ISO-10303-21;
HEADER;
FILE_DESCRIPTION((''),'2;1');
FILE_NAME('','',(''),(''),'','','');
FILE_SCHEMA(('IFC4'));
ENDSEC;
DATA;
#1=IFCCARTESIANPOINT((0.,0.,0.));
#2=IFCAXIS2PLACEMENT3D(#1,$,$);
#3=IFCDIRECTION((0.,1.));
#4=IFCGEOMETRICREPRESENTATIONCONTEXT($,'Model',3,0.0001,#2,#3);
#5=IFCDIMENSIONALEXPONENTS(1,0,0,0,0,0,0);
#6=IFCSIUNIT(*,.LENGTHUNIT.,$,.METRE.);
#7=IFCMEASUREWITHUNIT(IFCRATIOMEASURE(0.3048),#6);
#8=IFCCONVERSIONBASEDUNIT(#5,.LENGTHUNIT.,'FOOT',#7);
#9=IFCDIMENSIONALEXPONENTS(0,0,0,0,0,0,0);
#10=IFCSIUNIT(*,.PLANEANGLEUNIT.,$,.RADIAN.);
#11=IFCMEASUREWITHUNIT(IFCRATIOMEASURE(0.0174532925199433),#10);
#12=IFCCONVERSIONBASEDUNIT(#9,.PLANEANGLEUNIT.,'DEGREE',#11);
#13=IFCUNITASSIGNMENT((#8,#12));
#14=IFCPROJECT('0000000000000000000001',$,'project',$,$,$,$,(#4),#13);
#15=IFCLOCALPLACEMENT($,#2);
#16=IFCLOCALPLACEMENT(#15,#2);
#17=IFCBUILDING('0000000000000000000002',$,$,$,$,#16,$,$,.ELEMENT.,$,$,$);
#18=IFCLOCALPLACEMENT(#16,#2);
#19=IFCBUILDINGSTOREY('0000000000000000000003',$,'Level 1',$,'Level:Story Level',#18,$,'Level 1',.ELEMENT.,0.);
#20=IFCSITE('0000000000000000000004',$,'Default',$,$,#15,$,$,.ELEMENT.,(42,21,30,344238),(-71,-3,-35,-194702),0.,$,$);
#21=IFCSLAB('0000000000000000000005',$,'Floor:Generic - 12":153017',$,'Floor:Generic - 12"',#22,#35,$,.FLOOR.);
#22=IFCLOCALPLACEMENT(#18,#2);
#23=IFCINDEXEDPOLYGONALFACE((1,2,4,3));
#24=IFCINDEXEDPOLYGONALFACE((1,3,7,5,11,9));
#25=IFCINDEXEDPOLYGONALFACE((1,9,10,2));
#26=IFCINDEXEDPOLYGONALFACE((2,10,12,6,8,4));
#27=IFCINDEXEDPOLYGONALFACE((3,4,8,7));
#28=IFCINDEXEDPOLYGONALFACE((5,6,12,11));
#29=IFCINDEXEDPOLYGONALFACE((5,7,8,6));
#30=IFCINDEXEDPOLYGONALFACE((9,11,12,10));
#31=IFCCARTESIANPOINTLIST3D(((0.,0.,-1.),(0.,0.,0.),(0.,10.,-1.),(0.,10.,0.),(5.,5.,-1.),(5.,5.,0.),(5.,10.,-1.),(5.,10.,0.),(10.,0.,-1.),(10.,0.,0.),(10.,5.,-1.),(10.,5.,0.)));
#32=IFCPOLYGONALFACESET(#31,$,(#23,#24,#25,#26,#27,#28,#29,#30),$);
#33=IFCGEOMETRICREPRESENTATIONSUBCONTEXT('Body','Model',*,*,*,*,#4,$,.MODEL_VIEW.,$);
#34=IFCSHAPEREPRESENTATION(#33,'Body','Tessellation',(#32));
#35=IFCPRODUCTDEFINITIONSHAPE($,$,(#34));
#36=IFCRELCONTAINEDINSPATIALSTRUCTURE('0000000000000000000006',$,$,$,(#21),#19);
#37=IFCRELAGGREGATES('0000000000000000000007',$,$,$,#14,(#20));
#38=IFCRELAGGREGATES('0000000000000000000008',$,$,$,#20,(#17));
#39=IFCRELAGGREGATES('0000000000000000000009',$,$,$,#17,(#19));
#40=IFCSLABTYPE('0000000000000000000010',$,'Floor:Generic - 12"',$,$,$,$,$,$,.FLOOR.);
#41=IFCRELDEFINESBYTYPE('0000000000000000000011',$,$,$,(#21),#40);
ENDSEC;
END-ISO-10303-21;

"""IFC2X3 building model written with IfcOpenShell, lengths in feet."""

from ifc_helpers import new_model, entity, si_unit, converted_unit, direction, frame, origin, place, context, subcontext, project, spatial, polyline, outline, extrude, type_object, element, save


model = new_model("IFC2X3")

# Units and contexts
model_context = context("Model", 3, precision=0.0001, world=origin(), true_north=direction((0.0, 1.0)))
body_context = subcontext(model_context, "Body", "Model", "MODEL_VIEW")
ifc_project = project(units=[converted_unit("LENGTHUNIT", "FOOT", entity("IfcRatioMeasure", 0.3048), si_unit("LENGTHUNIT", "METRE"), dimensions=[1, 0, 0, 0, 0, 0, 0]), converted_unit("PLANEANGLEUNIT", "DEGREE", entity("IfcRatioMeasure", 0.0174532925199433), si_unit("PLANEANGLEUNIT", "RADIAN"), dimensions=[0, 0, 0, 0, 0, 0, 0])], contexts=[model_context])

# Site, building, storey
site_placement = place(None, origin())
site = spatial("IfcSite", under=ifc_project, at=site_placement, Name="Default", CompositionType="ELEMENT", RefLatitude=(42, 21, 30, 344238), RefLongitude=(-71, -3, -35, -194702), RefElevation=0.0)
building_placement = place(site_placement, origin())
building = spatial("IfcBuilding", under=site, at=building_placement, CompositionType="ELEMENT")
storey_placement = place(building_placement, origin())
storey = spatial("IfcBuildingStorey", under=building, at=storey_placement, Name="Level 1", ObjectType="Level:Story Level", LongName="Level 1", CompositionType="ELEMENT", Elevation=0.0)

# Slab
slab_type = type_object("IfcSlabType", Name="Floor:Generic - 12\"", PredefinedType="FLOOR")
slab_placement = place(storey_placement, origin())
element("IfcSlab", 1, at=slab_placement, inside=storey, type_object=slab_type, Name="Floor:Generic - 12\":153017", ObjectType="Floor:Generic - 12\"", PredefinedType="FLOOR", context=body_context, shape_type="SweptSolid", body=[
    extrude(outline(polyline([(-5.0, -5.0), (5.0, -5.0), (5.0, 0.0), (0.0, 0.0), (0.0, 5.0), (-5.0, 5.0), (-5.0, -5.0)])), frame((5.0, 5.0, 0.0), z_axis=(0.0, 0.0, -1.0), x_axis=(0.0, 1.0, 0.0)), (0.0, 0.0, 1.0), 1.0),
])

save(model, "model.ifc")
